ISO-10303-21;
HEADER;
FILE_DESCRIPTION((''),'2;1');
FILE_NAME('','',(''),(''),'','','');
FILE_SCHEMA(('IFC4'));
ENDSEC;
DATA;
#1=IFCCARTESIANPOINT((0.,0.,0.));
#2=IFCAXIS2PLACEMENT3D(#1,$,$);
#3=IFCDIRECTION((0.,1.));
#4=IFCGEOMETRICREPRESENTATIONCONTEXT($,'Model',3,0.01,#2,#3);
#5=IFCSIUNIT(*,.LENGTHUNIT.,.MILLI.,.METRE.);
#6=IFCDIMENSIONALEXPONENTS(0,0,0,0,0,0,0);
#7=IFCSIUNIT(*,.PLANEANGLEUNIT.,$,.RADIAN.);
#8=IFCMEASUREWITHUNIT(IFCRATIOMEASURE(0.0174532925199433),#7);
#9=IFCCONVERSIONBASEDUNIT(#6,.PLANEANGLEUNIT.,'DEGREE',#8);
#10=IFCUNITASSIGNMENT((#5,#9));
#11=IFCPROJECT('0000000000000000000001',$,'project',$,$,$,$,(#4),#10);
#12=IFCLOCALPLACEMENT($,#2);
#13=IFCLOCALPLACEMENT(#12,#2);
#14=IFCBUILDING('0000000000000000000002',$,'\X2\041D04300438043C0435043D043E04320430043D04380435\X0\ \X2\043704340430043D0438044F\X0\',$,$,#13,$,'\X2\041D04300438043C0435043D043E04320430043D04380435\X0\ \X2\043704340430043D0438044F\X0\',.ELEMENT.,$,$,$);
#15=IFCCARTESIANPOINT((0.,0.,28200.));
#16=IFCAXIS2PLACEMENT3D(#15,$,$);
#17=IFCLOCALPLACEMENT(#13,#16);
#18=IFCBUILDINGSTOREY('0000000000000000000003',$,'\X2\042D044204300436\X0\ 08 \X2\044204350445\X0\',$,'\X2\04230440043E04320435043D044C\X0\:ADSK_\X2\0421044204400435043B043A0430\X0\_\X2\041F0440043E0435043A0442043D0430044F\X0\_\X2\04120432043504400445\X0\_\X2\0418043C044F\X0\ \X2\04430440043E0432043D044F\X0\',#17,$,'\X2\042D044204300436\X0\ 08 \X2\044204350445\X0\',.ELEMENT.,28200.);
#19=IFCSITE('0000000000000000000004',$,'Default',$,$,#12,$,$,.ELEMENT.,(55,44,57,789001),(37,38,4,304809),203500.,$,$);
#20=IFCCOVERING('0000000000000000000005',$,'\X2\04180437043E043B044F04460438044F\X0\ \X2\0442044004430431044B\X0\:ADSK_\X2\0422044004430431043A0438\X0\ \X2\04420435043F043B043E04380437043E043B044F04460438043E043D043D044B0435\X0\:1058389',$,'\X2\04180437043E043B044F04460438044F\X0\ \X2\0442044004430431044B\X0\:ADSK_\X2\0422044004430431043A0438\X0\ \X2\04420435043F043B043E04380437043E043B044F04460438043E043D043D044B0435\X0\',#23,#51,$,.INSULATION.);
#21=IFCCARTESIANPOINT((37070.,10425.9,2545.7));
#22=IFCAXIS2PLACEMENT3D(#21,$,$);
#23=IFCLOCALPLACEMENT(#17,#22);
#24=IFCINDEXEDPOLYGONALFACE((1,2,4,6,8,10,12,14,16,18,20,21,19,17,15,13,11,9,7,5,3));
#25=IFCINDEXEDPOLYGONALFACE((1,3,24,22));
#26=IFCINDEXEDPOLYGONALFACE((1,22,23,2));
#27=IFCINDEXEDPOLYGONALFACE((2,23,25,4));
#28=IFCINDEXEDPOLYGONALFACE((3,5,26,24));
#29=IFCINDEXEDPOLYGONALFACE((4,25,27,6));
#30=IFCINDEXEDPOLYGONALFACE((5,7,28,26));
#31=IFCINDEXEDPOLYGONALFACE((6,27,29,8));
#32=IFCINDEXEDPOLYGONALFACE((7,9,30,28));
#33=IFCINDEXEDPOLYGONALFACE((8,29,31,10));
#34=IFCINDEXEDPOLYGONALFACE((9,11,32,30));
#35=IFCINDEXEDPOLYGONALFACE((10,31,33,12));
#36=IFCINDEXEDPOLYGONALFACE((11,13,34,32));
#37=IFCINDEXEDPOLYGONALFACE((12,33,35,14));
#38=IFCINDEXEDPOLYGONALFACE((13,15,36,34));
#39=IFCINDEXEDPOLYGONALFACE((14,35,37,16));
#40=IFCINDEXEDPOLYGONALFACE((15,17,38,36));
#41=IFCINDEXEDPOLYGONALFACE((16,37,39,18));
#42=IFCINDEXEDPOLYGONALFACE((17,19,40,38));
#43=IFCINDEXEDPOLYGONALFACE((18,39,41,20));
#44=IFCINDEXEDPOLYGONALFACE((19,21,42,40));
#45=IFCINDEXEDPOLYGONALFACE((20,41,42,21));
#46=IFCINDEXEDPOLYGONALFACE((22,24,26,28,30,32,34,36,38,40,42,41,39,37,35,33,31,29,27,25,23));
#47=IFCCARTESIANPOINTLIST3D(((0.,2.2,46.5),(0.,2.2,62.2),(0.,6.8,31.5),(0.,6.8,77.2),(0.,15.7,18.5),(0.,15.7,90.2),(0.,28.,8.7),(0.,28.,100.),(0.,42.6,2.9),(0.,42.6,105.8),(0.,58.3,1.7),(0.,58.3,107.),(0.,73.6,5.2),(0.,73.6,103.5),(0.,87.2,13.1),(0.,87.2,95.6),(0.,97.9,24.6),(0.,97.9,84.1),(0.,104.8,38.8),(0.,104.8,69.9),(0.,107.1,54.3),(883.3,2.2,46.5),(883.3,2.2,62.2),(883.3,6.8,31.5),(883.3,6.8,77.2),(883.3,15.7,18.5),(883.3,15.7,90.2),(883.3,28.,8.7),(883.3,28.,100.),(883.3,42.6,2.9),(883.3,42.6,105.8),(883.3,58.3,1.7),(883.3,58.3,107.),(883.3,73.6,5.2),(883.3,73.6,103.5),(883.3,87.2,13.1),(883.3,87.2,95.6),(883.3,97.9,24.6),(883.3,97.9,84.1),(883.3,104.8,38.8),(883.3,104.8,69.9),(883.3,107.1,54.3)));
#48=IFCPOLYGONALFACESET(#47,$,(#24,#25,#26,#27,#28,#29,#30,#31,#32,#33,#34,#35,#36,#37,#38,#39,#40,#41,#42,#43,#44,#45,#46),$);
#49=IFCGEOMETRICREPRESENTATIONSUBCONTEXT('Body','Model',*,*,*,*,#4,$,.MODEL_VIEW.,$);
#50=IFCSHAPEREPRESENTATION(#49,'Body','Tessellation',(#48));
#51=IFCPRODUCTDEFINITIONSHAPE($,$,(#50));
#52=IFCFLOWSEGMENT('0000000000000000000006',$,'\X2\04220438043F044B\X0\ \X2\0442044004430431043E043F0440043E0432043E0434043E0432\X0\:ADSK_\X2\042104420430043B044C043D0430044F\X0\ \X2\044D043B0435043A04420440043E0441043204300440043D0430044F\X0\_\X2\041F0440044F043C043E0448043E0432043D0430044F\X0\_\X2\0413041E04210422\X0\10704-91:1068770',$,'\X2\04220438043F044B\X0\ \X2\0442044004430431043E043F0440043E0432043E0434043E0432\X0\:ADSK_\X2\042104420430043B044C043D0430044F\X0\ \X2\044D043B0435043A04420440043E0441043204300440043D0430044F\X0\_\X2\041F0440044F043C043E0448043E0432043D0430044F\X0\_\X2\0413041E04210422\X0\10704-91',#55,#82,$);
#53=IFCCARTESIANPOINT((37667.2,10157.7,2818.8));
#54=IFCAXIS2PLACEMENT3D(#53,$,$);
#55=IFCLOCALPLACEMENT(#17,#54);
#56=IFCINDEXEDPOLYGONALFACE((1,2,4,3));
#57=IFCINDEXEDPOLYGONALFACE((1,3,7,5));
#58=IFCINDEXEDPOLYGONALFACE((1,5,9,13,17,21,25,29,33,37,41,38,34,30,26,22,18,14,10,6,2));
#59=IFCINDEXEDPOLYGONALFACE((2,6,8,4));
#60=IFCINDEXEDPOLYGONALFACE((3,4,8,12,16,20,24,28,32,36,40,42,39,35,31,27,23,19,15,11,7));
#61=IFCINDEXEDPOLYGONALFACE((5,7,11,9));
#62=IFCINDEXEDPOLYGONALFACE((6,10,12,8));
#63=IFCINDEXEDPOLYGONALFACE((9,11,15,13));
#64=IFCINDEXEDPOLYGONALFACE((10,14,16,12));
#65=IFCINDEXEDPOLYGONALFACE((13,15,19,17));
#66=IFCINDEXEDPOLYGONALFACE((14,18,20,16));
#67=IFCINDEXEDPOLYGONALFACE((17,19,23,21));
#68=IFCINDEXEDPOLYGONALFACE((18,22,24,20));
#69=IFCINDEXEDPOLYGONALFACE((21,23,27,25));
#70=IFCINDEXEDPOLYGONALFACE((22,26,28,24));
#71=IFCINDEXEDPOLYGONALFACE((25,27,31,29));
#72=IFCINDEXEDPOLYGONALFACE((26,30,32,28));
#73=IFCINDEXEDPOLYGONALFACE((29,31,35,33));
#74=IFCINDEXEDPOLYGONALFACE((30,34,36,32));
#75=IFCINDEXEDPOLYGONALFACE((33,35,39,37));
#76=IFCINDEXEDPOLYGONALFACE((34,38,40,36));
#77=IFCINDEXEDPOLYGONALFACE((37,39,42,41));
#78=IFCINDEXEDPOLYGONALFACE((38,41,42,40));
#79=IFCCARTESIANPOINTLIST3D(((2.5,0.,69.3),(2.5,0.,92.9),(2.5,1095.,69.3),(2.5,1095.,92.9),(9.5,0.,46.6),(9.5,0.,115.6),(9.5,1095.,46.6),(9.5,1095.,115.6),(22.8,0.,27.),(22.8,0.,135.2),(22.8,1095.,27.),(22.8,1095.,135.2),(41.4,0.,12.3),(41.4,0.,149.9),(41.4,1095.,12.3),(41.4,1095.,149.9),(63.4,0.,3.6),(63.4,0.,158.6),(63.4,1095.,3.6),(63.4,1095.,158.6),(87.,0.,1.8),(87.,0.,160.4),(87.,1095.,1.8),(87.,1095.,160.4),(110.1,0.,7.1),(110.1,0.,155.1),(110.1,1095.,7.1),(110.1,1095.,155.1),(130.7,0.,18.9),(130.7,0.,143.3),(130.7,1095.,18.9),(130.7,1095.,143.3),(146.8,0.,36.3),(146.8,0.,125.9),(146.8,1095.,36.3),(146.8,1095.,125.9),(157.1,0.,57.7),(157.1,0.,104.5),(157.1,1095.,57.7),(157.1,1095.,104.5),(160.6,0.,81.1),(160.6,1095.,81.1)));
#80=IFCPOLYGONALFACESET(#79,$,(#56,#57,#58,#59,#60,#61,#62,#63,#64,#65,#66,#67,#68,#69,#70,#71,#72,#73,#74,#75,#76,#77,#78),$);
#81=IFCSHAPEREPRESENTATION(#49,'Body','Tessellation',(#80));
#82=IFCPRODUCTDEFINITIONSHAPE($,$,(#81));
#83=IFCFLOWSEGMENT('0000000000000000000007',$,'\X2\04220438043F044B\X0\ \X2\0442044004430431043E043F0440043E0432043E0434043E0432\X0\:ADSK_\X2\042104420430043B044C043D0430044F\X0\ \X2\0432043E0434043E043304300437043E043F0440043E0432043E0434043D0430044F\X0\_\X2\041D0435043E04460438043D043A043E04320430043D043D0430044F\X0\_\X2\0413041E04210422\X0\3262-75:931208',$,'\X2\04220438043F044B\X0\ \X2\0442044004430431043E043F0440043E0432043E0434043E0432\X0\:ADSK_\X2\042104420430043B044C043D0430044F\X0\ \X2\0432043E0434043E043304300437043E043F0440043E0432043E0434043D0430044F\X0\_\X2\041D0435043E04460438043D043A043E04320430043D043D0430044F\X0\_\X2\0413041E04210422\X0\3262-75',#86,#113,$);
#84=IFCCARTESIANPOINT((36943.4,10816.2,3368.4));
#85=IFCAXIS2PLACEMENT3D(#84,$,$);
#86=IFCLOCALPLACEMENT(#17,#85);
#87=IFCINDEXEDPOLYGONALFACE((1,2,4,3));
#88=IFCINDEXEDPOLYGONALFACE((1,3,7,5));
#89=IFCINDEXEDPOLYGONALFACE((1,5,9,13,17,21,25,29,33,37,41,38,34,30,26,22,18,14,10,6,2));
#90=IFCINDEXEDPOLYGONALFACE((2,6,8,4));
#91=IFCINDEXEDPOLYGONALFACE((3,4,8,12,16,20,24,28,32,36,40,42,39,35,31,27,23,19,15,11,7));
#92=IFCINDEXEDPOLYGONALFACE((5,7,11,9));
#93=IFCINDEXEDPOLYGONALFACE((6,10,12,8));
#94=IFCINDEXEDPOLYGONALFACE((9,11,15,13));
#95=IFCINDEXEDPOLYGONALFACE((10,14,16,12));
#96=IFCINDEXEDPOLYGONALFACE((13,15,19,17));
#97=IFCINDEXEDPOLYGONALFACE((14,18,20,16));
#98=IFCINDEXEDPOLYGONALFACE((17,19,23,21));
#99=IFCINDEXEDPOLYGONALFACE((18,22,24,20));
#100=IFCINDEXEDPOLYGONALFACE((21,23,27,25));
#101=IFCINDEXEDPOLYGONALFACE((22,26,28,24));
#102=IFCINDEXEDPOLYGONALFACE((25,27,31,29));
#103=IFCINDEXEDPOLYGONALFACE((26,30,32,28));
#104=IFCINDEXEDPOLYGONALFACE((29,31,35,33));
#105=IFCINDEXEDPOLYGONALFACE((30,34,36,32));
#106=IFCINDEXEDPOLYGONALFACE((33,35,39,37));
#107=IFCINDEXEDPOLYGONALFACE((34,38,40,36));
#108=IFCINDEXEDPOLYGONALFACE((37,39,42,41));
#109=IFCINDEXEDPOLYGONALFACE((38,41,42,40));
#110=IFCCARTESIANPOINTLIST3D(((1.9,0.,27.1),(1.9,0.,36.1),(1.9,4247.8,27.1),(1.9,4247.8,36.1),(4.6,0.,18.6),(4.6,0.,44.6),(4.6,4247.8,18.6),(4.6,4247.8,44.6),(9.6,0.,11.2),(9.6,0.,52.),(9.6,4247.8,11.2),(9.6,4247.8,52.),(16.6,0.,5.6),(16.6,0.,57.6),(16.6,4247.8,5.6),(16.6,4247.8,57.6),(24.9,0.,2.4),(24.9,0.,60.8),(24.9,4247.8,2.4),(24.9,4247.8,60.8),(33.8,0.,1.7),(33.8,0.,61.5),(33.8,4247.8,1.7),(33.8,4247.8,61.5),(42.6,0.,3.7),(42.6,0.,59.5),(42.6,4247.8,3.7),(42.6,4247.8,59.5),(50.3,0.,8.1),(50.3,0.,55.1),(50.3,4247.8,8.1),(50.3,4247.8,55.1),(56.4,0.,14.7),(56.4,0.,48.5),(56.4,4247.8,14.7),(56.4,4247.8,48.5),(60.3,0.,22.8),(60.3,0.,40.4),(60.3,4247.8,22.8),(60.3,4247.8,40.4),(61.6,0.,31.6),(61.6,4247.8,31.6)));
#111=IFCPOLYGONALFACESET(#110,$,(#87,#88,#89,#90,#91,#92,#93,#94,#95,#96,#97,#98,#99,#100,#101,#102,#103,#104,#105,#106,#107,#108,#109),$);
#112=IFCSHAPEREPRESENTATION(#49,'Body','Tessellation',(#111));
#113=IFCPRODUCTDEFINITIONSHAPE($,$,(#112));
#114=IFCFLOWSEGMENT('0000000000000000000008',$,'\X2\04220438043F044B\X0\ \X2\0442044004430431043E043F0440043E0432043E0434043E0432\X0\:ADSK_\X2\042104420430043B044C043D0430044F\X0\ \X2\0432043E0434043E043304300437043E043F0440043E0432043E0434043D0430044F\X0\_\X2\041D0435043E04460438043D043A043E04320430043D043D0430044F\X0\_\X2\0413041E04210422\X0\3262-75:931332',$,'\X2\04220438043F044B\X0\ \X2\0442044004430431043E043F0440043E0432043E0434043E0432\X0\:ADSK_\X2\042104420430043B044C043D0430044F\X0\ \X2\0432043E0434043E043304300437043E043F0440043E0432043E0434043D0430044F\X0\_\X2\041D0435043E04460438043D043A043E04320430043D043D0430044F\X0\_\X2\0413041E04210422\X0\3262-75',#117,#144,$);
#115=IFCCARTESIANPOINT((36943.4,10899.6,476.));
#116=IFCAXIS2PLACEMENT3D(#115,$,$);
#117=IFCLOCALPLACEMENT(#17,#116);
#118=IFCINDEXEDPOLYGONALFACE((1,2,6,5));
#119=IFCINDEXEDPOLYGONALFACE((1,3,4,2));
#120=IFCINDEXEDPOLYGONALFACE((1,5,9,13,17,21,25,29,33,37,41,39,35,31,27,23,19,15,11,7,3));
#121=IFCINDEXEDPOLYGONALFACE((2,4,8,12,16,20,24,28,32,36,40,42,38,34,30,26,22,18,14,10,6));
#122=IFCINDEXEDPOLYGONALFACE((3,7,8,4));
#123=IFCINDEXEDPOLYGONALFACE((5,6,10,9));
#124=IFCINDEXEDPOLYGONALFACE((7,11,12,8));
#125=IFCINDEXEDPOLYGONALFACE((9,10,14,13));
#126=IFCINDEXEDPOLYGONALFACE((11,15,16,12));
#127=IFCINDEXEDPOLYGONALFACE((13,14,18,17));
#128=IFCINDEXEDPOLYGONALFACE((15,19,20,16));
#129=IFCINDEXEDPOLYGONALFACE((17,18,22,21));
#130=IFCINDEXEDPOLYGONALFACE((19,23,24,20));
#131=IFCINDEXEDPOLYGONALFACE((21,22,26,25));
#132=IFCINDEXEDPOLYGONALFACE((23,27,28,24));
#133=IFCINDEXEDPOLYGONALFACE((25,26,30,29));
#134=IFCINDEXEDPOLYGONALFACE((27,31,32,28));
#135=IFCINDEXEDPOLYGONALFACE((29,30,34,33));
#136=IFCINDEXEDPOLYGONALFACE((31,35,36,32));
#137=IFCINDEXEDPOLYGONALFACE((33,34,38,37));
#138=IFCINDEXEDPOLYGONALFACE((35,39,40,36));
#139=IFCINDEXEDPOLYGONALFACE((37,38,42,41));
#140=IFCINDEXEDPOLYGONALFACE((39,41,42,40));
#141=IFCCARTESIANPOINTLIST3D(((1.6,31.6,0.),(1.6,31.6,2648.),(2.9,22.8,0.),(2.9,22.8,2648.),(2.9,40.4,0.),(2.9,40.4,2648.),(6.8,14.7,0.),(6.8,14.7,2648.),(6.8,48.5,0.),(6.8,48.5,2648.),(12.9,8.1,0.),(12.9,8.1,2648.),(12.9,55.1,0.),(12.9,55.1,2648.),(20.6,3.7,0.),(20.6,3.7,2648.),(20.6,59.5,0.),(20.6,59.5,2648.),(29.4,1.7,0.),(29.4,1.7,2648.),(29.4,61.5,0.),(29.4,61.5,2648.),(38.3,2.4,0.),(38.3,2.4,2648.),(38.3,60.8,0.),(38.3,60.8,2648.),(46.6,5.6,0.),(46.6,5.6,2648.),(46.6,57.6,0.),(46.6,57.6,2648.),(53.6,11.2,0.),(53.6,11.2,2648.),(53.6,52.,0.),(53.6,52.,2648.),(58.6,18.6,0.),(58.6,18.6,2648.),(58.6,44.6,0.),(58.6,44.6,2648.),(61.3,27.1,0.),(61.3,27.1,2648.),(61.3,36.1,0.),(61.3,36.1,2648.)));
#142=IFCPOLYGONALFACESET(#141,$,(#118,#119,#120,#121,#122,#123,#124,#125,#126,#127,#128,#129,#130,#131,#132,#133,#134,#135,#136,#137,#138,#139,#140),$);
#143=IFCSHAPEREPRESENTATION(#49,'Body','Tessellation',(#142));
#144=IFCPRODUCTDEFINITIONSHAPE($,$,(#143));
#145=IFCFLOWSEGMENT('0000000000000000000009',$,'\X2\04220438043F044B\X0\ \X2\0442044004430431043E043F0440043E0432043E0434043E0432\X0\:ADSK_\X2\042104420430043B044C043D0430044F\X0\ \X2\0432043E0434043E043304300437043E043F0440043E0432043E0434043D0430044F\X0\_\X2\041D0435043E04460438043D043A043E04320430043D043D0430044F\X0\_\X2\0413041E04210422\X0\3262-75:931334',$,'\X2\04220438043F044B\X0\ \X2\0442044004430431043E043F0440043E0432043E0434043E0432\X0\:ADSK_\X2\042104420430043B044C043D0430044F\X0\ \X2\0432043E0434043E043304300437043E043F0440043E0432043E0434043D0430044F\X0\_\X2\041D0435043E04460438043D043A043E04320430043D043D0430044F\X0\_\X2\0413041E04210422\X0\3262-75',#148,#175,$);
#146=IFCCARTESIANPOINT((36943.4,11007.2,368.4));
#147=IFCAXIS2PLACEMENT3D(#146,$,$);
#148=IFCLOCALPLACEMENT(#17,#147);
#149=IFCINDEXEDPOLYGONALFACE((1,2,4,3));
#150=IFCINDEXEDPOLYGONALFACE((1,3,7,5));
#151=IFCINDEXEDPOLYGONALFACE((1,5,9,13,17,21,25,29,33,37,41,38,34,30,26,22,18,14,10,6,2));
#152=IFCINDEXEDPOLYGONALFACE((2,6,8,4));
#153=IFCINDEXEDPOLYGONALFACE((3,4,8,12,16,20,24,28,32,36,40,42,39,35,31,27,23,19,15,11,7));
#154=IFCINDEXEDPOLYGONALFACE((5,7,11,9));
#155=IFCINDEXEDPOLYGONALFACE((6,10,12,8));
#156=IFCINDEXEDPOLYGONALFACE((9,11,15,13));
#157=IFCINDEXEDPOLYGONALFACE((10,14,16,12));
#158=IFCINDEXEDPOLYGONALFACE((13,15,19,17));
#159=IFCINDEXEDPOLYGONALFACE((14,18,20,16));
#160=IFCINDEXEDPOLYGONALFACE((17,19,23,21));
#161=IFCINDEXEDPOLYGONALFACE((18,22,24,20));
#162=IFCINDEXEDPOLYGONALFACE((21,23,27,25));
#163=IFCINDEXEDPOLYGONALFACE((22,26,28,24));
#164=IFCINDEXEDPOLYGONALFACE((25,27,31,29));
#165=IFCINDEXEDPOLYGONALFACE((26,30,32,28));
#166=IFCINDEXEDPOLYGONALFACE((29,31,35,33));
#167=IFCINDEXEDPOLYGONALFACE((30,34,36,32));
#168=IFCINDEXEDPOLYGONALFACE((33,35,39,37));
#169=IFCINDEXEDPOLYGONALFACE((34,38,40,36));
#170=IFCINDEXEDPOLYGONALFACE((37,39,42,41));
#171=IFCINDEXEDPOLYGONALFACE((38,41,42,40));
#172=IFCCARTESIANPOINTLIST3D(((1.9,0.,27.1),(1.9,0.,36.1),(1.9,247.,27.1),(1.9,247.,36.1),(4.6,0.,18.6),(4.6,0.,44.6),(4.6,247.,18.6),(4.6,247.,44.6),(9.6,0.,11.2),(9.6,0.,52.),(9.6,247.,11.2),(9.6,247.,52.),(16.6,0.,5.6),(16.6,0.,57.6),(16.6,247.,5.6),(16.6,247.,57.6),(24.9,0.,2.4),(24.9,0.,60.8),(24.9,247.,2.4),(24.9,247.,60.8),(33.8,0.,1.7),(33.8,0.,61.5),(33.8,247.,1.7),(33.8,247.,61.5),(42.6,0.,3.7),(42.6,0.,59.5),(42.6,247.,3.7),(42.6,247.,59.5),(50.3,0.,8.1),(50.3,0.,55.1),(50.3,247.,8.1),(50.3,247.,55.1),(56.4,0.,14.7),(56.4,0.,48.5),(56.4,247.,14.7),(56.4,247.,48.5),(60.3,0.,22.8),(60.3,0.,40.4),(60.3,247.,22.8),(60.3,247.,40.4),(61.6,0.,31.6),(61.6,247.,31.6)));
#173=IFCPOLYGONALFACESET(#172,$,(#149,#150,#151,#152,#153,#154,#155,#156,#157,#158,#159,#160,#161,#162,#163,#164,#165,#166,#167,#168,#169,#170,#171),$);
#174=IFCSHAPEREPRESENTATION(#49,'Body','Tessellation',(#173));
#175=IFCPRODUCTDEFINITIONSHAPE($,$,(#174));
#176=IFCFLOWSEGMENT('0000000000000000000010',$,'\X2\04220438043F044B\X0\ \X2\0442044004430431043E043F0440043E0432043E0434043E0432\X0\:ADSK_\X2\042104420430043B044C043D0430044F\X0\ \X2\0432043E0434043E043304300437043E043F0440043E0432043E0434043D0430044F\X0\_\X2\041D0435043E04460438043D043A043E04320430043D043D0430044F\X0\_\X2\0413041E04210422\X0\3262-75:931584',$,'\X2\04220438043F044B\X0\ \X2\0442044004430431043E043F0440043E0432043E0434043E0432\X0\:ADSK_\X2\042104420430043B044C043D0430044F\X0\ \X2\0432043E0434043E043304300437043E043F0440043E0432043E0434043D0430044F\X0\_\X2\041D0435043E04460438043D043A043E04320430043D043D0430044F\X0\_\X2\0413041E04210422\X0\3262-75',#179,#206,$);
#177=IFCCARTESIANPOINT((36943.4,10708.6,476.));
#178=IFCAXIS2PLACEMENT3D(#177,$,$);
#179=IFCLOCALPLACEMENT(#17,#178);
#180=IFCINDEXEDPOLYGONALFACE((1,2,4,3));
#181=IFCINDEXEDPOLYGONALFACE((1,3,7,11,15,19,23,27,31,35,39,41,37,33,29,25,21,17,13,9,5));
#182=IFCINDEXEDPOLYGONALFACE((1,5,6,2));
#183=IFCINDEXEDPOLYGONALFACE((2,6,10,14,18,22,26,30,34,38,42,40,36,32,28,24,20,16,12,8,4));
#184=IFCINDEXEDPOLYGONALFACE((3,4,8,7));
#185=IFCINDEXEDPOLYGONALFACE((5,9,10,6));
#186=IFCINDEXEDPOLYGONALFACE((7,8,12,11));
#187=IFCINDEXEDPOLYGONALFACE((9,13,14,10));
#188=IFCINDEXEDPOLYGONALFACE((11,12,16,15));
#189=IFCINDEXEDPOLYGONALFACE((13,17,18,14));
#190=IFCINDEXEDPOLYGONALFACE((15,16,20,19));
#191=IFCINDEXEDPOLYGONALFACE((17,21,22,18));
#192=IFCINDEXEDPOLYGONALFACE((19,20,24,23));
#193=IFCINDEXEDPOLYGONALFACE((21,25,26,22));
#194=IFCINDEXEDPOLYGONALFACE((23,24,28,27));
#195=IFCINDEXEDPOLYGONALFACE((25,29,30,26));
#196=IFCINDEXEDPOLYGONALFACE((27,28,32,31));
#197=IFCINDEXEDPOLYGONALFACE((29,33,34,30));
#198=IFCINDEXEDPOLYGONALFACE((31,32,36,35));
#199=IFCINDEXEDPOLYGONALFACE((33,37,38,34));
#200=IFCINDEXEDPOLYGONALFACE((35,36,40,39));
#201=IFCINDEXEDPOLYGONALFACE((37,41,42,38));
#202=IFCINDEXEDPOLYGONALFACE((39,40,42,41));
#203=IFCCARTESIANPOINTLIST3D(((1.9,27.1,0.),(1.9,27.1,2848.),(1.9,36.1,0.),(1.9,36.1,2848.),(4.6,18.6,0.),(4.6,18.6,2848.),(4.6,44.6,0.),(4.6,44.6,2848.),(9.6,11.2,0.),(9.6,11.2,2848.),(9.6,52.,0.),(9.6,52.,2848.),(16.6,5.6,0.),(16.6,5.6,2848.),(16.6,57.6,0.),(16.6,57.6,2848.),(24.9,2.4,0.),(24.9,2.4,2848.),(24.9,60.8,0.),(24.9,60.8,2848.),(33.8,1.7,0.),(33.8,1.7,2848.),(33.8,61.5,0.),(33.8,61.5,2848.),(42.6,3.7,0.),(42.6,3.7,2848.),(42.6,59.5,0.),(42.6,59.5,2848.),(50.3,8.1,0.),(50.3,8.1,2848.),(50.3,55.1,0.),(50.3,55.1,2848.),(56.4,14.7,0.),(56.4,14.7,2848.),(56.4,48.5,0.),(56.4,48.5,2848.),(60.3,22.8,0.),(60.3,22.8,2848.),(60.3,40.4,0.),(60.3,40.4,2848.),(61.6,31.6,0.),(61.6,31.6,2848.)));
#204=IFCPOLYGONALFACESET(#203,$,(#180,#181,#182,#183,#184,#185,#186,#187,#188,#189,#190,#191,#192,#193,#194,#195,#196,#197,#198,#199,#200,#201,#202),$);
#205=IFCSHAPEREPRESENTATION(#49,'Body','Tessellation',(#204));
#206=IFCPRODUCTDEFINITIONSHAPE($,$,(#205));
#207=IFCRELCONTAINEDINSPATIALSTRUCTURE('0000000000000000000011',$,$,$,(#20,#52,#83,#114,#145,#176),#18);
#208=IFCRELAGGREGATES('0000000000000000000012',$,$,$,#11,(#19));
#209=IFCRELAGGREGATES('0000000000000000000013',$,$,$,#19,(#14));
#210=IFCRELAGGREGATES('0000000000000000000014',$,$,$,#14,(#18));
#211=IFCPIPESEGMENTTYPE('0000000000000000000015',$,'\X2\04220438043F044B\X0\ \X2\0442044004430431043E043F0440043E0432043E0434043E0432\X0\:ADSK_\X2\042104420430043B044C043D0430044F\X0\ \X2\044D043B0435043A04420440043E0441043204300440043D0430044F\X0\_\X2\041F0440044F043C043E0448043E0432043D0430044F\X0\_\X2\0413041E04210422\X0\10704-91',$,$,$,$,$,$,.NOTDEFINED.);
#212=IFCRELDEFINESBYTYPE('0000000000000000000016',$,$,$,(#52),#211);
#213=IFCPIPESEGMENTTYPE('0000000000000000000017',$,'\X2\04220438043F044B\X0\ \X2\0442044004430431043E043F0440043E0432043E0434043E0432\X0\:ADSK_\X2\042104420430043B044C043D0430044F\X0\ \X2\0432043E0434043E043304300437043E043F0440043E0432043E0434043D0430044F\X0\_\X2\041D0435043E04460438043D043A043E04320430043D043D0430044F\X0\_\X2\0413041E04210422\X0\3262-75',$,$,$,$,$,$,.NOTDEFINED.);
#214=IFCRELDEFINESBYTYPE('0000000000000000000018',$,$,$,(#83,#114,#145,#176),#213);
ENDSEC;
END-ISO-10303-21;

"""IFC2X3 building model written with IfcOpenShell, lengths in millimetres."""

from ifc_helpers import new_model, entity, si_unit, converted_unit, direction, frame, origin, origin_2d_with_axis, place, context, subcontext, project, spatial, circle, extrude, type_object, element, save


model = new_model("IFC2X3")

# Units and contexts
model_context = context("Model", 3, precision=0.01, world=origin(), true_north=direction((0.0, 1.0)))
body_context = subcontext(model_context, "Body", "Model", "MODEL_VIEW")
ifc_project = project(units=[si_unit("LENGTHUNIT", "METRE", prefix="MILLI"), converted_unit("PLANEANGLEUNIT", "DEGREE", entity("IfcRatioMeasure", 0.0174532925199433), si_unit("PLANEANGLEUNIT", "RADIAN"), dimensions=[0, 0, 0, 0, 0, 0, 0])], contexts=[model_context])

# Site, building, storey
site_placement = place(None, origin())
site = spatial("IfcSite", under=ifc_project, at=site_placement, Name="Default", CompositionType="ELEMENT", RefLatitude=(55, 44, 57, 789001), RefLongitude=(37, 38, 4, 304809), RefElevation=203500.0)
building_placement = place(site_placement, origin())
building = spatial("IfcBuilding", under=site, at=building_placement, Name="Наименование здания", LongName="Наименование здания", CompositionType="ELEMENT")
storey_placement = place(building_placement, frame((0.0, 0.0, 28200.0)))
storey = spatial("IfcBuildingStorey", under=building, at=storey_placement, Name="Этаж 08 тех", ObjectType="Уровень:ADSK_Стрелка_Проектная_Вверх_Имя уровня", LongName="Этаж 08 тех", CompositionType="ELEMENT", Elevation=28200.0)

# Covering
covering_1_placement = place(storey_placement, frame((37070.0, 10425.9, 2545.7)))
element("IfcCovering", 1, at=covering_1_placement, inside=storey, Name="Изоляция трубы:ADSK_Трубки теплоизоляционные:1058389", ObjectType="Изоляция трубы:ADSK_Трубки теплоизоляционные", PredefinedType="INSULATION", context=body_context, shape_type="SweptSolid", body=[
    extrude(circle(Radius=52.8, at=origin_2d_with_axis()), frame((0.0, 54.4, 54.4), z_axis=(1.0, 0.0, 0.0), x_axis=(0.0, 1.0, 0.0)), (0.0, 0.0, 1.0), 883.3),
])

# Flow segments
pipe_segment_type_1 = type_object("IfcPipeSegmentType", Name="Типы трубопроводов:ADSK_Стальная электросварная_Прямошовная_ГОСТ10704-91", PredefinedType="NOTDEFINED")
flow_segment_1_placement = place(storey_placement, frame((37667.2, 10157.7, 2818.8)))
element("IfcFlowSegment", 2, at=flow_segment_1_placement, inside=storey, type_object=pipe_segment_type_1, Name="Типы трубопроводов:ADSK_Стальная электросварная_Прямошовная_ГОСТ10704-91:1068770", ObjectType="Типы трубопроводов:ADSK_Стальная электросварная_Прямошовная_ГОСТ10704-91", context=body_context, shape_type="SweptSolid", body=[
    extrude(circle(Radius=79.5, at=origin_2d_with_axis()), frame((81.1, 0.0, 81.1), z_axis=(0.0, 1.0, 0.0), x_axis=(1.0, 0.0, 0.0)), (0.0, 0.0, 1.0), 1095.0),
])
pipe_segment_type_2 = type_object("IfcPipeSegmentType", Name="Типы трубопроводов:ADSK_Стальная водогазопроводная_Неоцинкованная_ГОСТ3262-75", PredefinedType="NOTDEFINED")
flow_segment_2_placement = place(storey_placement, frame((36943.4, 10816.2, 3368.4)))
element("IfcFlowSegment", 3, at=flow_segment_2_placement, inside=storey, type_object=pipe_segment_type_2, Name="Типы трубопроводов:ADSK_Стальная водогазопроводная_Неоцинкованная_ГОСТ3262-75:931208", ObjectType="Типы трубопроводов:ADSK_Стальная водогазопроводная_Неоцинкованная_ГОСТ3262-75", context=body_context, shape_type="SweptSolid", body=[
    extrude(circle(Radius=30.0, at=origin_2d_with_axis()), frame((31.6, 0.0, 31.6), z_axis=(0.0, 1.0, 0.0), x_axis=(1.0, 0.0, 0.0)), (0.0, 0.0, 1.0), 4247.8),
])
flow_segment_3_placement = place(storey_placement, frame((36943.4, 10899.6, 476.0)))
element("IfcFlowSegment", 4, at=flow_segment_3_placement, inside=storey, type_object=pipe_segment_type_2, Name="Типы трубопроводов:ADSK_Стальная водогазопроводная_Неоцинкованная_ГОСТ3262-75:931332", ObjectType="Типы трубопроводов:ADSK_Стальная водогазопроводная_Неоцинкованная_ГОСТ3262-75", context=body_context, shape_type="SweptSolid", body=[
    extrude(circle(Radius=30.0, at=origin_2d_with_axis()), frame((31.6, 31.6, 0.0), z_axis=(0.0, 0.0, 1.0), x_axis=(-1.0, 0.0, 0.0)), (0.0, 0.0, 1.0), 2648.0),
])
flow_segment_4_placement = place(storey_placement, frame((36943.4, 11007.2, 368.4)))
element("IfcFlowSegment", 5, at=flow_segment_4_placement, inside=storey, type_object=pipe_segment_type_2, Name="Типы трубопроводов:ADSK_Стальная водогазопроводная_Неоцинкованная_ГОСТ3262-75:931334", ObjectType="Типы трубопроводов:ADSK_Стальная водогазопроводная_Неоцинкованная_ГОСТ3262-75", context=body_context, shape_type="SweptSolid", body=[
    extrude(circle(Radius=30.0, at=origin_2d_with_axis()), frame((31.6, 0.0, 31.6), z_axis=(0.0, 1.0, 0.0), x_axis=(1.0, 0.0, 0.0)), (0.0, 0.0, 1.0), 247.0),
])
flow_segment_5_placement = place(storey_placement, frame((36943.4, 10708.6, 476.0)))
element("IfcFlowSegment", 6, at=flow_segment_5_placement, inside=storey, type_object=pipe_segment_type_2, Name="Типы трубопроводов:ADSK_Стальная водогазопроводная_Неоцинкованная_ГОСТ3262-75:931584", ObjectType="Типы трубопроводов:ADSK_Стальная водогазопроводная_Неоцинкованная_ГОСТ3262-75", context=body_context, shape_type="SweptSolid", body=[
    extrude(circle(Radius=30.0, at=origin_2d_with_axis()), frame((31.6, 31.6, 0.0)), (0.0, 0.0, 1.0), 2848.0),
])

save(model, "model.ifc")
